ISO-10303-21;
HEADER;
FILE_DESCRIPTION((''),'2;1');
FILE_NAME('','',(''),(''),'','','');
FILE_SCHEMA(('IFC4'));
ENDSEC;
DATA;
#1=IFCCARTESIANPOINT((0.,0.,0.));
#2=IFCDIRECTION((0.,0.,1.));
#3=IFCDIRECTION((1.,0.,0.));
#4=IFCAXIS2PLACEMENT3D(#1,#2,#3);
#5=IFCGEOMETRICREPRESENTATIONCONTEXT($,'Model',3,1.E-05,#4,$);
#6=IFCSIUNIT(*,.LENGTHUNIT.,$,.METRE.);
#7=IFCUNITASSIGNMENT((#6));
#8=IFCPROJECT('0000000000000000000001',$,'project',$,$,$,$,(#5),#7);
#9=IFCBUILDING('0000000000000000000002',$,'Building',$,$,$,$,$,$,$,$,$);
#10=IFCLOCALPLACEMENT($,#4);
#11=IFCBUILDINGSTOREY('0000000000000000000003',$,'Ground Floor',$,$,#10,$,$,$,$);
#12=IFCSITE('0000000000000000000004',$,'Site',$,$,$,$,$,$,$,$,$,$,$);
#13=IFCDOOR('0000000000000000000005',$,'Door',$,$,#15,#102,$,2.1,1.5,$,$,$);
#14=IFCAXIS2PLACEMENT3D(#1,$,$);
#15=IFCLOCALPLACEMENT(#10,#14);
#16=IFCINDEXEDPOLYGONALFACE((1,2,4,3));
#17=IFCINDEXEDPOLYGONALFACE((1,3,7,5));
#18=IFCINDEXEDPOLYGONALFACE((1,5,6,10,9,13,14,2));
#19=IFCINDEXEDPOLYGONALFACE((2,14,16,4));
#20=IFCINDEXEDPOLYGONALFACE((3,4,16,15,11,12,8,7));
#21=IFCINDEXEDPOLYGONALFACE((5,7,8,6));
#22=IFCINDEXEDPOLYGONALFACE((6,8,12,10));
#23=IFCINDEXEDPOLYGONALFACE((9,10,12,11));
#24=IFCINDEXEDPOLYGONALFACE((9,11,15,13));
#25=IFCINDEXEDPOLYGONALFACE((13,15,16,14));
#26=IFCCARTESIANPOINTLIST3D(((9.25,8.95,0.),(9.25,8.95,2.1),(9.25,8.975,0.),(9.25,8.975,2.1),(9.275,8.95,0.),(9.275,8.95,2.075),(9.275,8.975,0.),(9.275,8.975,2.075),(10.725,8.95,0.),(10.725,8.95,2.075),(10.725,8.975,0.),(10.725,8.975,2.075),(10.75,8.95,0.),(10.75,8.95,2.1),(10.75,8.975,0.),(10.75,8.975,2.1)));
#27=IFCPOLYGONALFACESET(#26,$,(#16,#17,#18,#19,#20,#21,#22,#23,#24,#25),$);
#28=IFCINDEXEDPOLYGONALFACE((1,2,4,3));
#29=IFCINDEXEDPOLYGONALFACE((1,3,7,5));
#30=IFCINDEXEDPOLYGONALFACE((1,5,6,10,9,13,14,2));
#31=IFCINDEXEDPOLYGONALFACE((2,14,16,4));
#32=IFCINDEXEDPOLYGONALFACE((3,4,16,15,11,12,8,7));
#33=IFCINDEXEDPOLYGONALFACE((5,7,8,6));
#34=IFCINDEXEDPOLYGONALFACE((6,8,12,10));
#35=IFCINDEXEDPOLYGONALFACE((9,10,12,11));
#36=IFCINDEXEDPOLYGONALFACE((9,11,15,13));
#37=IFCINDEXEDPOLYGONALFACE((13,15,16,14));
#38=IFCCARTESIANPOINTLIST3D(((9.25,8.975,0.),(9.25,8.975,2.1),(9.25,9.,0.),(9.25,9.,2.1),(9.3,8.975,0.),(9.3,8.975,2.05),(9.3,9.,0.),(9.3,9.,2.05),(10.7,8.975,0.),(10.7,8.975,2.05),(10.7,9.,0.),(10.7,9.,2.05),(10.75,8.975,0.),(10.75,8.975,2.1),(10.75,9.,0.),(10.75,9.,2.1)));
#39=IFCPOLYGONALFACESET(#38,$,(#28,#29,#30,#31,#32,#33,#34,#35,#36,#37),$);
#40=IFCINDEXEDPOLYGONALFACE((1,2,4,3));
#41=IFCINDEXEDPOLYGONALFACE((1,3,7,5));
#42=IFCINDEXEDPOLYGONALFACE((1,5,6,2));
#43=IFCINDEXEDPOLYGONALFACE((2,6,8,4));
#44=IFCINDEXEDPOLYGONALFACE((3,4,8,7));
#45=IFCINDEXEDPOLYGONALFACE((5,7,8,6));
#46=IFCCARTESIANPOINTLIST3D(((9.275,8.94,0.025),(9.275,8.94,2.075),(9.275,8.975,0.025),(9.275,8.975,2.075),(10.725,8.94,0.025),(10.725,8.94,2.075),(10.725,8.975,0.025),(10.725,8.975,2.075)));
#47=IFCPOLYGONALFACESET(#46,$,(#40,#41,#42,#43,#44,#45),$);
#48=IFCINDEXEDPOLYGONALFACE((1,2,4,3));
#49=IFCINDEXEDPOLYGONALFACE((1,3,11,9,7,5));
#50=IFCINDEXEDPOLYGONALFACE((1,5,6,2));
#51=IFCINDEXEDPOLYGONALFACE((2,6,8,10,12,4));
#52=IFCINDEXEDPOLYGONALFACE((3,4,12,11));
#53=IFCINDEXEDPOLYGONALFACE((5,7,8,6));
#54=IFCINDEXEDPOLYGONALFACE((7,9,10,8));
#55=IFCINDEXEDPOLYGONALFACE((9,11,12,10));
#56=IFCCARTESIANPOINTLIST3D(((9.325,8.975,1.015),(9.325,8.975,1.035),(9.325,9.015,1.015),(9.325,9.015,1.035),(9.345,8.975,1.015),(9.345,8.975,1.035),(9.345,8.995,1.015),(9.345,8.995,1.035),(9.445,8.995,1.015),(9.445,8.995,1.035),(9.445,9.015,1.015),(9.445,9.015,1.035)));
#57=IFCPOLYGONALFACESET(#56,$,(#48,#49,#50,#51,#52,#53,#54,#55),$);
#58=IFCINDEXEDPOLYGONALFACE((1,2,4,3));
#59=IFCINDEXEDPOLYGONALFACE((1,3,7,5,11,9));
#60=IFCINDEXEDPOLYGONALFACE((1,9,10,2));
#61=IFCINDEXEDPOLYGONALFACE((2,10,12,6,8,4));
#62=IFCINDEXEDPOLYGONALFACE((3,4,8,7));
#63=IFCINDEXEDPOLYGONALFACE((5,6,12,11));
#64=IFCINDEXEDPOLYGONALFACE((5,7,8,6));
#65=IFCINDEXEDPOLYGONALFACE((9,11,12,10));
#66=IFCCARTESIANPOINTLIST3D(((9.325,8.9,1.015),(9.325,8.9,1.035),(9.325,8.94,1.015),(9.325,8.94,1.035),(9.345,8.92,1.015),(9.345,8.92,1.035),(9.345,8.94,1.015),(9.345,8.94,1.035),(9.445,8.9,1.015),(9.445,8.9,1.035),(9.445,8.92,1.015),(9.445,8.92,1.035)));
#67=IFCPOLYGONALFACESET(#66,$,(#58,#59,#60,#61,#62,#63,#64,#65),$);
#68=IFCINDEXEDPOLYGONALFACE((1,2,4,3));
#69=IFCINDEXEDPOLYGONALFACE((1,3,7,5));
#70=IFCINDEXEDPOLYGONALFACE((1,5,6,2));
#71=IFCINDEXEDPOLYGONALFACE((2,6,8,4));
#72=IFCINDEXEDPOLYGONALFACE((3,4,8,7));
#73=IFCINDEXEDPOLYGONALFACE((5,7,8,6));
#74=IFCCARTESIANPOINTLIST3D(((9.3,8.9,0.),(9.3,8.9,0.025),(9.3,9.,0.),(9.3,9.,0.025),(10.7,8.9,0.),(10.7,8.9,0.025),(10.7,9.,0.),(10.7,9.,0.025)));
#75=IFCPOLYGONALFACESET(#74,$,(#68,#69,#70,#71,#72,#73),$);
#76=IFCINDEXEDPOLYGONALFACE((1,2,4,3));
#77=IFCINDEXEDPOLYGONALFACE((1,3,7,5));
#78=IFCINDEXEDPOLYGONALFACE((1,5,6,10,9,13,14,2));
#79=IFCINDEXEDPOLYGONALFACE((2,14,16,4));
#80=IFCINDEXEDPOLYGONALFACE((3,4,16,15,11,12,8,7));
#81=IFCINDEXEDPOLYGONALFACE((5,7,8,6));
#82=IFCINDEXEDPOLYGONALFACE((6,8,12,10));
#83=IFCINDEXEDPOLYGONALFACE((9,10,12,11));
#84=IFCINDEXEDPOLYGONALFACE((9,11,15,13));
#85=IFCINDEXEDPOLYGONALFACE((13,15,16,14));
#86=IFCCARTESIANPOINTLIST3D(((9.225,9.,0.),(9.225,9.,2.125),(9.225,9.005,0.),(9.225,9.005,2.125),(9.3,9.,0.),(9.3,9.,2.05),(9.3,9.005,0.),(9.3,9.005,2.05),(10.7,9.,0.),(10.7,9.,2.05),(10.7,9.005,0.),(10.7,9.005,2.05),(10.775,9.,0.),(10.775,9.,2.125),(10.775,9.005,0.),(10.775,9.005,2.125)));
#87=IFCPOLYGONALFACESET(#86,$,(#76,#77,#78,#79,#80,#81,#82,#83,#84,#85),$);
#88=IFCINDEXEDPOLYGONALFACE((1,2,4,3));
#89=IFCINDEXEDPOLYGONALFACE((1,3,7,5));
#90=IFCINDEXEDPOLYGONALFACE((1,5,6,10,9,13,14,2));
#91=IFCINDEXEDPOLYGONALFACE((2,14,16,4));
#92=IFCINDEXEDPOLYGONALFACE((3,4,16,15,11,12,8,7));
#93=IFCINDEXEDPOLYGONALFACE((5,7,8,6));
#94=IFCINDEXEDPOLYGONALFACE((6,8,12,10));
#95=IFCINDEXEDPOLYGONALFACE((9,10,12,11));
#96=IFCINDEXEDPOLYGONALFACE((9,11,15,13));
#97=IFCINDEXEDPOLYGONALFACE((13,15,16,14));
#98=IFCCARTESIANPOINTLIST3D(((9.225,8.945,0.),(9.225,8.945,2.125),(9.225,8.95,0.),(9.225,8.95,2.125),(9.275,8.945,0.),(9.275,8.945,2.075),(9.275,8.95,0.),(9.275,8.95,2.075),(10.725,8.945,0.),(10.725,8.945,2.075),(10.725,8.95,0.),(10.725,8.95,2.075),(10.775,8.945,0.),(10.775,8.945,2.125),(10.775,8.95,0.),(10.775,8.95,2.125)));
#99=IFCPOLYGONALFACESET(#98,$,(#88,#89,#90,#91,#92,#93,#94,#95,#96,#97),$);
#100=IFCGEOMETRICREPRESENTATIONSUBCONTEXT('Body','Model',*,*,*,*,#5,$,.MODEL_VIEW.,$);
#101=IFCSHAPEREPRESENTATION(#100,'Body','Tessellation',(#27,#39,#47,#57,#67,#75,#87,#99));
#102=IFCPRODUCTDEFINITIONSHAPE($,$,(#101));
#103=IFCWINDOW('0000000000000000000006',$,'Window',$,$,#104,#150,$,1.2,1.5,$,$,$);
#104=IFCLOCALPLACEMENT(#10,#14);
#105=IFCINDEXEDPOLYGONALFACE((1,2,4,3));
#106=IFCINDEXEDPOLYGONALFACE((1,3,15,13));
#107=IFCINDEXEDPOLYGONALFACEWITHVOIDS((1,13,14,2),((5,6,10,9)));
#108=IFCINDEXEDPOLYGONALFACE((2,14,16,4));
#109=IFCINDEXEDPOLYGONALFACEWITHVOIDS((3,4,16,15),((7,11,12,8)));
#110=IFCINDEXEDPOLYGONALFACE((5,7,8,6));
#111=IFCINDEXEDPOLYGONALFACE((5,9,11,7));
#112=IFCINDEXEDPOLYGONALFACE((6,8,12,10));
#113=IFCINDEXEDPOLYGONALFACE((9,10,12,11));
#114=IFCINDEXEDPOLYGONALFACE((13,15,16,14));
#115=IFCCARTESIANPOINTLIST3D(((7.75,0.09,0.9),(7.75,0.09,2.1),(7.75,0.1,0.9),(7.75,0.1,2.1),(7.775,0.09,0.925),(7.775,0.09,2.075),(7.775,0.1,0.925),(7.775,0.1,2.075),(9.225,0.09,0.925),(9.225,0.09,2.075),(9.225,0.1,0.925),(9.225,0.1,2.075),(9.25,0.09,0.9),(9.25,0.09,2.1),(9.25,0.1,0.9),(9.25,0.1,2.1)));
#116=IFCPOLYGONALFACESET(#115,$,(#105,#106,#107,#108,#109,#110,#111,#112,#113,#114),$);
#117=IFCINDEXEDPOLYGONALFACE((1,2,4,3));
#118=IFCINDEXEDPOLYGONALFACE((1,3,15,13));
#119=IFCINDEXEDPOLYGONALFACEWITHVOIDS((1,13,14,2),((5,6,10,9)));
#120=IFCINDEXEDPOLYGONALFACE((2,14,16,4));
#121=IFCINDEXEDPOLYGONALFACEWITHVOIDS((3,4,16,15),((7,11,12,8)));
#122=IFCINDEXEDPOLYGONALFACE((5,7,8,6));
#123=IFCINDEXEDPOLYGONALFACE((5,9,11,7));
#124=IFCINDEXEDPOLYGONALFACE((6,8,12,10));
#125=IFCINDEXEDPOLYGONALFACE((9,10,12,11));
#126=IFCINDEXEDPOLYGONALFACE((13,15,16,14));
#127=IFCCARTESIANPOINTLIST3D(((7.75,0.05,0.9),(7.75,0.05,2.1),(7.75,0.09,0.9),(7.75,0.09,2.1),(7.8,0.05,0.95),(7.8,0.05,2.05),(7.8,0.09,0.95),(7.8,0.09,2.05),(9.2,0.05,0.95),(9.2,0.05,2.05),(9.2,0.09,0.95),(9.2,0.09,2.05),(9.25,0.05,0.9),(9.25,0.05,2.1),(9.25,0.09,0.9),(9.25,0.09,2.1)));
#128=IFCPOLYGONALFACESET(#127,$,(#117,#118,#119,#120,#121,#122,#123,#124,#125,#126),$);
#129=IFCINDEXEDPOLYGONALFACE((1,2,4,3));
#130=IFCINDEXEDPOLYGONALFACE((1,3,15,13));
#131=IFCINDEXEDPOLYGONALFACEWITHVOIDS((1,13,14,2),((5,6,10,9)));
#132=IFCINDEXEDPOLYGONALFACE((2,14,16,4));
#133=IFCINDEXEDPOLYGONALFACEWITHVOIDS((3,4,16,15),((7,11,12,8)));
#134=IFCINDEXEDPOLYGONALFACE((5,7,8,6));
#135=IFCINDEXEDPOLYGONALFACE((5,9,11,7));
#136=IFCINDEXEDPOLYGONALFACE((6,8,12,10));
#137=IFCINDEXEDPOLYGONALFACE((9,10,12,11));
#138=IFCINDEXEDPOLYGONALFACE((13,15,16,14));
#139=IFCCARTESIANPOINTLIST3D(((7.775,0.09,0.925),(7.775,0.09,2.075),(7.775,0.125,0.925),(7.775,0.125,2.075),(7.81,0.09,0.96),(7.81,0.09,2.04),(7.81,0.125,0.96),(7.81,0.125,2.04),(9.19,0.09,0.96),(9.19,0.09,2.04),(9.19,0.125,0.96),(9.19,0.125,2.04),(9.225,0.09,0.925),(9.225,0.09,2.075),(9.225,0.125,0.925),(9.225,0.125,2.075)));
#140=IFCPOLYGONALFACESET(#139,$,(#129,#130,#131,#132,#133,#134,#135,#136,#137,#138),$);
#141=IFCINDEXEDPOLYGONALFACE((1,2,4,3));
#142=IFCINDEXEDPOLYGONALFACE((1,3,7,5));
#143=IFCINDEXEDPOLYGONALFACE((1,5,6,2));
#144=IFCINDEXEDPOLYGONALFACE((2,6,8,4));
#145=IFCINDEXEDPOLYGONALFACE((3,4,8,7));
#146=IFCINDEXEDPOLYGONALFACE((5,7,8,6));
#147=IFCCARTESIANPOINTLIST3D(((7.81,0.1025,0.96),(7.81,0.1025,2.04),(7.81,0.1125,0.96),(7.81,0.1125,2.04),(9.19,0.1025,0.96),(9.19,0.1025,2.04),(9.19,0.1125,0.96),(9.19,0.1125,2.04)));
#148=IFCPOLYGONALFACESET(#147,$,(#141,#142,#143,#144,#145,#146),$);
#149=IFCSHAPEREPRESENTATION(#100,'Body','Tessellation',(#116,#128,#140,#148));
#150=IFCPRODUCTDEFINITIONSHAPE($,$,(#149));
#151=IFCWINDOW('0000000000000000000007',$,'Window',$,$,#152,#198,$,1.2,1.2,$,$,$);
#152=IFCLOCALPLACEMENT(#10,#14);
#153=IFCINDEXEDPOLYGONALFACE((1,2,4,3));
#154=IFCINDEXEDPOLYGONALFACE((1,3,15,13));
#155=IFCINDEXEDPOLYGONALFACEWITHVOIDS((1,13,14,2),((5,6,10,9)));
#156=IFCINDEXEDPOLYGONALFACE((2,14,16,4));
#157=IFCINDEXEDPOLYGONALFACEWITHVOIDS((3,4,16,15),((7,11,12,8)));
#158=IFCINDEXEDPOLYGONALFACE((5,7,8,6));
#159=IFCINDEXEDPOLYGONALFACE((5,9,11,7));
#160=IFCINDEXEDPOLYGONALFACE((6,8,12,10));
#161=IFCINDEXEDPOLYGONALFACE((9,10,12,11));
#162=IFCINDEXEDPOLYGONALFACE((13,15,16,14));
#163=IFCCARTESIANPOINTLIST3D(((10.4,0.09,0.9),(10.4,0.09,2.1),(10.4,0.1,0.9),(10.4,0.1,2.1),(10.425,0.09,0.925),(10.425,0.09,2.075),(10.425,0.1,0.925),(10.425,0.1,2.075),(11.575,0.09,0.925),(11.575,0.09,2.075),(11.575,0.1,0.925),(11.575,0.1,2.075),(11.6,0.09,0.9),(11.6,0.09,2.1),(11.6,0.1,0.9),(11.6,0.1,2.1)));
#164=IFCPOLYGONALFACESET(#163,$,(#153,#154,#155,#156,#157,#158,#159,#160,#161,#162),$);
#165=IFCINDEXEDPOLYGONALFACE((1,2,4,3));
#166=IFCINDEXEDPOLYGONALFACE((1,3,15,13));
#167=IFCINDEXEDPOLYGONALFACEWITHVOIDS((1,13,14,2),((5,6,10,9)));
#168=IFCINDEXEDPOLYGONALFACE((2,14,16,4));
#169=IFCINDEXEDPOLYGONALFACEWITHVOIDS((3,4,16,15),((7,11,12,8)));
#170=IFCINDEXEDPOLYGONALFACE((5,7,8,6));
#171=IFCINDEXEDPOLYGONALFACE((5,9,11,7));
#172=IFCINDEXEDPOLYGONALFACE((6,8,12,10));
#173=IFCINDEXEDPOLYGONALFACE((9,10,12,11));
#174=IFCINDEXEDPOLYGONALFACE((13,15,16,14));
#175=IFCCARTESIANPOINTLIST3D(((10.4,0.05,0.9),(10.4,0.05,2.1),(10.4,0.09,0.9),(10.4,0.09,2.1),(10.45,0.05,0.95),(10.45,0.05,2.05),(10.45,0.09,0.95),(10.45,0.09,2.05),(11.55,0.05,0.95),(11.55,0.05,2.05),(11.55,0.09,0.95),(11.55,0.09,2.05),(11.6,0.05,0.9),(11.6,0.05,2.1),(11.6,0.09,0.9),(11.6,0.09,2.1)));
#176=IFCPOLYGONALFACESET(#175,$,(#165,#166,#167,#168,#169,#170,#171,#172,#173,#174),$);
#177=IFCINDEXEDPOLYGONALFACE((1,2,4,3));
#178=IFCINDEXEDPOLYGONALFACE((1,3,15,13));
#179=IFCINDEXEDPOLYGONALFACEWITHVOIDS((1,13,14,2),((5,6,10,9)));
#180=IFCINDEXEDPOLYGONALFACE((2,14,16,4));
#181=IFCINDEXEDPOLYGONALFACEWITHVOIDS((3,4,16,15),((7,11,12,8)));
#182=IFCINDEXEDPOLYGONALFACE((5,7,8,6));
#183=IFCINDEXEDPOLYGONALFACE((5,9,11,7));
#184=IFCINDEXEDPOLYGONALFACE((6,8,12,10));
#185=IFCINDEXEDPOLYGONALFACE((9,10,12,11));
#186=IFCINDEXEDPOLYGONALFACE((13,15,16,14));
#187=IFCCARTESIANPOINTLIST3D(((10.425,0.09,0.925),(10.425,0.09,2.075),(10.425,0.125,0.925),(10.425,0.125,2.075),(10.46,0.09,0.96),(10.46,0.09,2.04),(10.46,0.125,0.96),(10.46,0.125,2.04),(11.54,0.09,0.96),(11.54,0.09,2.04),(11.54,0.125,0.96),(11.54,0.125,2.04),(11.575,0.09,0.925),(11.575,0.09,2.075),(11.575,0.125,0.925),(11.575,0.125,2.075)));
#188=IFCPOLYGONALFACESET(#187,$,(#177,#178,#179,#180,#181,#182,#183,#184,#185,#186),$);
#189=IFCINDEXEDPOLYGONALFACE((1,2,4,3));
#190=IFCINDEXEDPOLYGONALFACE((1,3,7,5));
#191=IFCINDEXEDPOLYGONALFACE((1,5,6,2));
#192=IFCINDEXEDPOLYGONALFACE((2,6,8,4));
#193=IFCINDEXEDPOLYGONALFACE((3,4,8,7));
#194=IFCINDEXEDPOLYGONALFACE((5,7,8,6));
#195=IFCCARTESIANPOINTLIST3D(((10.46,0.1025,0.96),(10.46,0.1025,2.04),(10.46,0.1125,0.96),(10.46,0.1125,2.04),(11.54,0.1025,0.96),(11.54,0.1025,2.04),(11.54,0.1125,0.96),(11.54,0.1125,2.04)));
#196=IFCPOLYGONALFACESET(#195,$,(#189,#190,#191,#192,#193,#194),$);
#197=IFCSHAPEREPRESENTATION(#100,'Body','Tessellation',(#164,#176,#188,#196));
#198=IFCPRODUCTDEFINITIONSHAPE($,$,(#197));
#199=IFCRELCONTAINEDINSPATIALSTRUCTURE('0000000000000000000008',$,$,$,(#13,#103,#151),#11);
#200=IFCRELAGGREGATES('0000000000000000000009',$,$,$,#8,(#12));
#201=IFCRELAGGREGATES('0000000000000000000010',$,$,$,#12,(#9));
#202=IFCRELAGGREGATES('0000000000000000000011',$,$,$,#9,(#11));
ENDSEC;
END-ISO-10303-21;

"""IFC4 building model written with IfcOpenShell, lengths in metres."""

from ifc_helpers import new_model, si_unit, frame, origin_with_axes, place, context, subcontext, project, spatial, line, indexed_curve, outline, extrude, element, save


model = new_model("IFC4")

# Units and contexts
model_context = context("Model", 3, precision=1e-05, world=origin_with_axes())
body_context = subcontext(model_context, "Body", "Model", "MODEL_VIEW")
ifc_project = project(units=[si_unit("LENGTHUNIT", "METRE")], contexts=[model_context])

# Site, building, storey
site = spatial("IfcSite", under=ifc_project, Name="Site")
building = spatial("IfcBuilding", under=site, Name="Building")
storey_placement = place(None, origin_with_axes())
storey = spatial("IfcBuildingStorey", under=building, at=storey_placement, Name="Ground Floor")

# Door
door_1_placement = place(storey_placement, frame((10.75, 9.0, 0.0), z_axis=(0.0, 0.0, 1.0), x_axis=(-1.0, 0.0, 0.0)))
element("IfcDoor", 1, at=door_1_placement, inside=storey, Name="Door", OverallHeight=2.1, OverallWidth=1.5, context=body_context, shape_type="SweptSolid", body=[
    extrude(outline(indexed_curve([(0.0, 0.0), (0.0, 2.1), (1.5, 2.1), (1.5, 0.0), (1.475, 0.0), (1.475, 2.075), (0.025, 2.075), (0.025, 0.0)], segments=[line(1, 2, 3, 4, 5, 6, 7, 8, 1)])), frame((0.0, 0.025, 0.0), z_axis=(0.0, -1.0, 0.0), x_axis=(1.0, 0.0, 0.0)), (0.0, 0.0, -1.0), 0.025),
    extrude(outline(indexed_curve([(0.0, 0.0), (0.0, 2.1), (1.5, 2.1), (1.5, 0.0), (1.45, 0.0), (1.45, 2.05), (0.05, 2.05), (0.05, 0.0)], segments=[line(1, 2, 3, 4, 5, 6, 7, 8, 1)])), frame((0.0, 0.0, 0.0), z_axis=(0.0, -1.0, 0.0), x_axis=(1.0, 0.0, 0.0)), (0.0, 0.0, -1.0), 0.025),
    extrude(outline(indexed_curve([(0.0, 0.0), (1.45, 0.0), (1.45, 0.035), (0.0, 0.035)], segments=[line(1, 2, 3, 4, 1)])), frame((0.025, 0.025, 0.025), z_axis=(0.0, 0.0, 1.0), x_axis=(1.0, 0.0, 0.0)), (0.0, 0.0, 1.0), 2.05),
    extrude(outline(indexed_curve([(0.0, 0.0), (0.0, -0.04), (-0.12, -0.04), (-0.12, -0.02), (-0.02, -0.02), (-0.02, 0.0)], segments=[line(1, 2, 3, 4, 5, 6, 1)])), frame((1.425, 0.025, 1.015), z_axis=(0.0, 0.0, 1.0), x_axis=(1.0, 0.0, 0.0)), (0.0, 0.0, 1.0), 0.02),
    extrude(outline(indexed_curve([(0.0, 0.0), (0.0, 0.04), (-0.12, 0.04), (-0.12, 0.02), (-0.02, 0.02), (-0.02, 0.0)], segments=[line(1, 2, 3, 4, 5, 6, 1)])), frame((1.425, 0.06, 1.015), z_axis=(0.0, 0.0, 1.0), x_axis=(1.0, 0.0, 0.0)), (0.0, 0.0, 1.0), 0.02),
    extrude(outline(indexed_curve([(0.0, 0.0), (1.4, 0.0), (1.4, 0.1), (0.0, 0.1)], segments=[line(1, 2, 3, 4, 1)])), frame((0.05, 0.0, 0.0), z_axis=(0.0, 0.0, 1.0), x_axis=(1.0, 0.0, 0.0)), (0.0, 0.0, 1.0), 0.025),
    extrude(outline(indexed_curve([(0.0, 0.0), (0.0, 2.125), (1.55, 2.125), (1.55, 0.0), (1.475, 0.0), (1.475, 2.05), (0.075, 2.05), (0.075, 0.0)], segments=[line(1, 2, 3, 4, 5, 6, 7, 8, 1)])), frame((-0.025, -0.005, 0.0), z_axis=(0.0, -1.0, 0.0), x_axis=(1.0, 0.0, 0.0)), (0.0, 0.0, -1.0), 0.005),
    extrude(outline(indexed_curve([(0.0, 0.0), (0.0, 2.125), (1.55, 2.125), (1.55, 0.0), (1.5, 0.0), (1.5, 2.075), (0.05, 2.075), (0.05, 0.0)], segments=[line(1, 2, 3, 4, 5, 6, 7, 8, 1)])), frame((-0.025, 0.05, 0.0), z_axis=(0.0, -1.0, 0.0), x_axis=(1.0, 0.0, 0.0)), (0.0, 0.0, -1.0), 0.005),
])

# Windows
window_1_placement = place(storey_placement, frame((7.75, 0.0, 0.9), z_axis=(0.0, 0.0, 1.0), x_axis=(1.0, 0.0, 0.0)))
element("IfcWindow", 2, at=window_1_placement, inside=storey, Name="Window", OverallHeight=1.2, OverallWidth=1.5, context=body_context, shape_type="SweptSolid", body=[
    extrude(outline(indexed_curve([(0.0, 0.0), (1.5, 0.0), (1.5, 1.2), (0.0, 1.2)], segments=[line(1, 2, 3, 4, 1)]), holes=[indexed_curve([(0.025, 0.025), (1.475, 0.025), (1.475, 1.175), (0.025, 1.175)], segments=[line(1, 2, 3, 4, 1)])]), frame((0.0, 0.09, 0.0), z_axis=(0.0, -1.0, 0.0), x_axis=(1.0, 0.0, 0.0)), (0.0, 0.0, -1.0), 0.01),
    extrude(outline(indexed_curve([(0.0, 0.0), (1.5, 0.0), (1.5, 1.2), (0.0, 1.2)], segments=[line(1, 2, 3, 4, 1)]), holes=[indexed_curve([(0.05, 0.05), (1.45, 0.05), (1.45, 1.15), (0.05, 1.15)], segments=[line(1, 2, 3, 4, 1)])]), frame((0.0, 0.05, 0.0), z_axis=(0.0, -1.0, 0.0), x_axis=(1.0, 0.0, 0.0)), (0.0, 0.0, -1.0), 0.04),
    extrude(outline(indexed_curve([(0.0, 0.0), (1.45, 0.0), (1.45, 1.15), (0.0, 1.15)], segments=[line(1, 2, 3, 4, 1)]), holes=[indexed_curve([(0.035, 0.035), (1.415, 0.035), (1.415, 1.115), (0.035, 1.115)], segments=[line(1, 2, 3, 4, 1)])]), frame((0.025, 0.09, 0.025), z_axis=(0.0, -1.0, 0.0), x_axis=(1.0, 0.0, 0.0)), (0.0, 0.0, -1.0), 0.035),
    extrude(outline(indexed_curve([(0.035, 0.035), (1.415, 0.035), (1.415, 1.115), (0.035, 1.115)], segments=[line(1, 2, 3, 4, 1)])), frame((0.025, 0.1025, 0.025), z_axis=(0.0, -1.0, 0.0), x_axis=(1.0, 0.0, 0.0)), (0.0, 0.0, -1.0), 0.01),
])
window_2_placement = place(storey_placement, frame((10.4, 0.0, 0.9), z_axis=(0.0, 0.0, 1.0), x_axis=(1.0, 0.0, 0.0)))
element("IfcWindow", 3, at=window_2_placement, inside=storey, Name="Window", OverallHeight=1.2, OverallWidth=1.2, context=body_context, shape_type="SweptSolid", body=[
    extrude(outline(indexed_curve([(0.0, 0.0), (1.2, 0.0), (1.2, 1.2), (0.0, 1.2)], segments=[line(1, 2, 3, 4, 1)]), holes=[indexed_curve([(0.025, 0.025), (1.175, 0.025), (1.175, 1.175), (0.025, 1.175)], segments=[line(1, 2, 3, 4, 1)])]), frame((0.0, 0.09, 0.0), z_axis=(0.0, -1.0, 0.0), x_axis=(1.0, 0.0, 0.0)), (0.0, 0.0, -1.0), 0.01),
    extrude(outline(indexed_curve([(0.0, 0.0), (1.2, 0.0), (1.2, 1.2), (0.0, 1.2)], segments=[line(1, 2, 3, 4, 1)]), holes=[indexed_curve([(0.05, 0.05), (1.15, 0.05), (1.15, 1.15), (0.05, 1.15)], segments=[line(1, 2, 3, 4, 1)])]), frame((0.0, 0.05, 0.0), z_axis=(0.0, -1.0, 0.0), x_axis=(1.0, 0.0, 0.0)), (0.0, 0.0, -1.0), 0.04),
    extrude(outline(indexed_curve([(0.0, 0.0), (1.15, 0.0), (1.15, 1.15), (0.0, 1.15)], segments=[line(1, 2, 3, 4, 1)]), holes=[indexed_curve([(0.035, 0.035), (1.115, 0.035), (1.115, 1.115), (0.035, 1.115)], segments=[line(1, 2, 3, 4, 1)])]), frame((0.025, 0.09, 0.025), z_axis=(0.0, -1.0, 0.0), x_axis=(1.0, 0.0, 0.0)), (0.0, 0.0, -1.0), 0.035),
    extrude(outline(indexed_curve([(0.035, 0.035), (1.115, 0.035), (1.115, 1.115), (0.035, 1.115)], segments=[line(1, 2, 3, 4, 1)])), frame((0.025, 0.1025, 0.025), z_axis=(0.0, -1.0, 0.0), x_axis=(1.0, 0.0, 0.0)), (0.0, 0.0, -1.0), 0.01),
])

save(model, "model.ifc")
